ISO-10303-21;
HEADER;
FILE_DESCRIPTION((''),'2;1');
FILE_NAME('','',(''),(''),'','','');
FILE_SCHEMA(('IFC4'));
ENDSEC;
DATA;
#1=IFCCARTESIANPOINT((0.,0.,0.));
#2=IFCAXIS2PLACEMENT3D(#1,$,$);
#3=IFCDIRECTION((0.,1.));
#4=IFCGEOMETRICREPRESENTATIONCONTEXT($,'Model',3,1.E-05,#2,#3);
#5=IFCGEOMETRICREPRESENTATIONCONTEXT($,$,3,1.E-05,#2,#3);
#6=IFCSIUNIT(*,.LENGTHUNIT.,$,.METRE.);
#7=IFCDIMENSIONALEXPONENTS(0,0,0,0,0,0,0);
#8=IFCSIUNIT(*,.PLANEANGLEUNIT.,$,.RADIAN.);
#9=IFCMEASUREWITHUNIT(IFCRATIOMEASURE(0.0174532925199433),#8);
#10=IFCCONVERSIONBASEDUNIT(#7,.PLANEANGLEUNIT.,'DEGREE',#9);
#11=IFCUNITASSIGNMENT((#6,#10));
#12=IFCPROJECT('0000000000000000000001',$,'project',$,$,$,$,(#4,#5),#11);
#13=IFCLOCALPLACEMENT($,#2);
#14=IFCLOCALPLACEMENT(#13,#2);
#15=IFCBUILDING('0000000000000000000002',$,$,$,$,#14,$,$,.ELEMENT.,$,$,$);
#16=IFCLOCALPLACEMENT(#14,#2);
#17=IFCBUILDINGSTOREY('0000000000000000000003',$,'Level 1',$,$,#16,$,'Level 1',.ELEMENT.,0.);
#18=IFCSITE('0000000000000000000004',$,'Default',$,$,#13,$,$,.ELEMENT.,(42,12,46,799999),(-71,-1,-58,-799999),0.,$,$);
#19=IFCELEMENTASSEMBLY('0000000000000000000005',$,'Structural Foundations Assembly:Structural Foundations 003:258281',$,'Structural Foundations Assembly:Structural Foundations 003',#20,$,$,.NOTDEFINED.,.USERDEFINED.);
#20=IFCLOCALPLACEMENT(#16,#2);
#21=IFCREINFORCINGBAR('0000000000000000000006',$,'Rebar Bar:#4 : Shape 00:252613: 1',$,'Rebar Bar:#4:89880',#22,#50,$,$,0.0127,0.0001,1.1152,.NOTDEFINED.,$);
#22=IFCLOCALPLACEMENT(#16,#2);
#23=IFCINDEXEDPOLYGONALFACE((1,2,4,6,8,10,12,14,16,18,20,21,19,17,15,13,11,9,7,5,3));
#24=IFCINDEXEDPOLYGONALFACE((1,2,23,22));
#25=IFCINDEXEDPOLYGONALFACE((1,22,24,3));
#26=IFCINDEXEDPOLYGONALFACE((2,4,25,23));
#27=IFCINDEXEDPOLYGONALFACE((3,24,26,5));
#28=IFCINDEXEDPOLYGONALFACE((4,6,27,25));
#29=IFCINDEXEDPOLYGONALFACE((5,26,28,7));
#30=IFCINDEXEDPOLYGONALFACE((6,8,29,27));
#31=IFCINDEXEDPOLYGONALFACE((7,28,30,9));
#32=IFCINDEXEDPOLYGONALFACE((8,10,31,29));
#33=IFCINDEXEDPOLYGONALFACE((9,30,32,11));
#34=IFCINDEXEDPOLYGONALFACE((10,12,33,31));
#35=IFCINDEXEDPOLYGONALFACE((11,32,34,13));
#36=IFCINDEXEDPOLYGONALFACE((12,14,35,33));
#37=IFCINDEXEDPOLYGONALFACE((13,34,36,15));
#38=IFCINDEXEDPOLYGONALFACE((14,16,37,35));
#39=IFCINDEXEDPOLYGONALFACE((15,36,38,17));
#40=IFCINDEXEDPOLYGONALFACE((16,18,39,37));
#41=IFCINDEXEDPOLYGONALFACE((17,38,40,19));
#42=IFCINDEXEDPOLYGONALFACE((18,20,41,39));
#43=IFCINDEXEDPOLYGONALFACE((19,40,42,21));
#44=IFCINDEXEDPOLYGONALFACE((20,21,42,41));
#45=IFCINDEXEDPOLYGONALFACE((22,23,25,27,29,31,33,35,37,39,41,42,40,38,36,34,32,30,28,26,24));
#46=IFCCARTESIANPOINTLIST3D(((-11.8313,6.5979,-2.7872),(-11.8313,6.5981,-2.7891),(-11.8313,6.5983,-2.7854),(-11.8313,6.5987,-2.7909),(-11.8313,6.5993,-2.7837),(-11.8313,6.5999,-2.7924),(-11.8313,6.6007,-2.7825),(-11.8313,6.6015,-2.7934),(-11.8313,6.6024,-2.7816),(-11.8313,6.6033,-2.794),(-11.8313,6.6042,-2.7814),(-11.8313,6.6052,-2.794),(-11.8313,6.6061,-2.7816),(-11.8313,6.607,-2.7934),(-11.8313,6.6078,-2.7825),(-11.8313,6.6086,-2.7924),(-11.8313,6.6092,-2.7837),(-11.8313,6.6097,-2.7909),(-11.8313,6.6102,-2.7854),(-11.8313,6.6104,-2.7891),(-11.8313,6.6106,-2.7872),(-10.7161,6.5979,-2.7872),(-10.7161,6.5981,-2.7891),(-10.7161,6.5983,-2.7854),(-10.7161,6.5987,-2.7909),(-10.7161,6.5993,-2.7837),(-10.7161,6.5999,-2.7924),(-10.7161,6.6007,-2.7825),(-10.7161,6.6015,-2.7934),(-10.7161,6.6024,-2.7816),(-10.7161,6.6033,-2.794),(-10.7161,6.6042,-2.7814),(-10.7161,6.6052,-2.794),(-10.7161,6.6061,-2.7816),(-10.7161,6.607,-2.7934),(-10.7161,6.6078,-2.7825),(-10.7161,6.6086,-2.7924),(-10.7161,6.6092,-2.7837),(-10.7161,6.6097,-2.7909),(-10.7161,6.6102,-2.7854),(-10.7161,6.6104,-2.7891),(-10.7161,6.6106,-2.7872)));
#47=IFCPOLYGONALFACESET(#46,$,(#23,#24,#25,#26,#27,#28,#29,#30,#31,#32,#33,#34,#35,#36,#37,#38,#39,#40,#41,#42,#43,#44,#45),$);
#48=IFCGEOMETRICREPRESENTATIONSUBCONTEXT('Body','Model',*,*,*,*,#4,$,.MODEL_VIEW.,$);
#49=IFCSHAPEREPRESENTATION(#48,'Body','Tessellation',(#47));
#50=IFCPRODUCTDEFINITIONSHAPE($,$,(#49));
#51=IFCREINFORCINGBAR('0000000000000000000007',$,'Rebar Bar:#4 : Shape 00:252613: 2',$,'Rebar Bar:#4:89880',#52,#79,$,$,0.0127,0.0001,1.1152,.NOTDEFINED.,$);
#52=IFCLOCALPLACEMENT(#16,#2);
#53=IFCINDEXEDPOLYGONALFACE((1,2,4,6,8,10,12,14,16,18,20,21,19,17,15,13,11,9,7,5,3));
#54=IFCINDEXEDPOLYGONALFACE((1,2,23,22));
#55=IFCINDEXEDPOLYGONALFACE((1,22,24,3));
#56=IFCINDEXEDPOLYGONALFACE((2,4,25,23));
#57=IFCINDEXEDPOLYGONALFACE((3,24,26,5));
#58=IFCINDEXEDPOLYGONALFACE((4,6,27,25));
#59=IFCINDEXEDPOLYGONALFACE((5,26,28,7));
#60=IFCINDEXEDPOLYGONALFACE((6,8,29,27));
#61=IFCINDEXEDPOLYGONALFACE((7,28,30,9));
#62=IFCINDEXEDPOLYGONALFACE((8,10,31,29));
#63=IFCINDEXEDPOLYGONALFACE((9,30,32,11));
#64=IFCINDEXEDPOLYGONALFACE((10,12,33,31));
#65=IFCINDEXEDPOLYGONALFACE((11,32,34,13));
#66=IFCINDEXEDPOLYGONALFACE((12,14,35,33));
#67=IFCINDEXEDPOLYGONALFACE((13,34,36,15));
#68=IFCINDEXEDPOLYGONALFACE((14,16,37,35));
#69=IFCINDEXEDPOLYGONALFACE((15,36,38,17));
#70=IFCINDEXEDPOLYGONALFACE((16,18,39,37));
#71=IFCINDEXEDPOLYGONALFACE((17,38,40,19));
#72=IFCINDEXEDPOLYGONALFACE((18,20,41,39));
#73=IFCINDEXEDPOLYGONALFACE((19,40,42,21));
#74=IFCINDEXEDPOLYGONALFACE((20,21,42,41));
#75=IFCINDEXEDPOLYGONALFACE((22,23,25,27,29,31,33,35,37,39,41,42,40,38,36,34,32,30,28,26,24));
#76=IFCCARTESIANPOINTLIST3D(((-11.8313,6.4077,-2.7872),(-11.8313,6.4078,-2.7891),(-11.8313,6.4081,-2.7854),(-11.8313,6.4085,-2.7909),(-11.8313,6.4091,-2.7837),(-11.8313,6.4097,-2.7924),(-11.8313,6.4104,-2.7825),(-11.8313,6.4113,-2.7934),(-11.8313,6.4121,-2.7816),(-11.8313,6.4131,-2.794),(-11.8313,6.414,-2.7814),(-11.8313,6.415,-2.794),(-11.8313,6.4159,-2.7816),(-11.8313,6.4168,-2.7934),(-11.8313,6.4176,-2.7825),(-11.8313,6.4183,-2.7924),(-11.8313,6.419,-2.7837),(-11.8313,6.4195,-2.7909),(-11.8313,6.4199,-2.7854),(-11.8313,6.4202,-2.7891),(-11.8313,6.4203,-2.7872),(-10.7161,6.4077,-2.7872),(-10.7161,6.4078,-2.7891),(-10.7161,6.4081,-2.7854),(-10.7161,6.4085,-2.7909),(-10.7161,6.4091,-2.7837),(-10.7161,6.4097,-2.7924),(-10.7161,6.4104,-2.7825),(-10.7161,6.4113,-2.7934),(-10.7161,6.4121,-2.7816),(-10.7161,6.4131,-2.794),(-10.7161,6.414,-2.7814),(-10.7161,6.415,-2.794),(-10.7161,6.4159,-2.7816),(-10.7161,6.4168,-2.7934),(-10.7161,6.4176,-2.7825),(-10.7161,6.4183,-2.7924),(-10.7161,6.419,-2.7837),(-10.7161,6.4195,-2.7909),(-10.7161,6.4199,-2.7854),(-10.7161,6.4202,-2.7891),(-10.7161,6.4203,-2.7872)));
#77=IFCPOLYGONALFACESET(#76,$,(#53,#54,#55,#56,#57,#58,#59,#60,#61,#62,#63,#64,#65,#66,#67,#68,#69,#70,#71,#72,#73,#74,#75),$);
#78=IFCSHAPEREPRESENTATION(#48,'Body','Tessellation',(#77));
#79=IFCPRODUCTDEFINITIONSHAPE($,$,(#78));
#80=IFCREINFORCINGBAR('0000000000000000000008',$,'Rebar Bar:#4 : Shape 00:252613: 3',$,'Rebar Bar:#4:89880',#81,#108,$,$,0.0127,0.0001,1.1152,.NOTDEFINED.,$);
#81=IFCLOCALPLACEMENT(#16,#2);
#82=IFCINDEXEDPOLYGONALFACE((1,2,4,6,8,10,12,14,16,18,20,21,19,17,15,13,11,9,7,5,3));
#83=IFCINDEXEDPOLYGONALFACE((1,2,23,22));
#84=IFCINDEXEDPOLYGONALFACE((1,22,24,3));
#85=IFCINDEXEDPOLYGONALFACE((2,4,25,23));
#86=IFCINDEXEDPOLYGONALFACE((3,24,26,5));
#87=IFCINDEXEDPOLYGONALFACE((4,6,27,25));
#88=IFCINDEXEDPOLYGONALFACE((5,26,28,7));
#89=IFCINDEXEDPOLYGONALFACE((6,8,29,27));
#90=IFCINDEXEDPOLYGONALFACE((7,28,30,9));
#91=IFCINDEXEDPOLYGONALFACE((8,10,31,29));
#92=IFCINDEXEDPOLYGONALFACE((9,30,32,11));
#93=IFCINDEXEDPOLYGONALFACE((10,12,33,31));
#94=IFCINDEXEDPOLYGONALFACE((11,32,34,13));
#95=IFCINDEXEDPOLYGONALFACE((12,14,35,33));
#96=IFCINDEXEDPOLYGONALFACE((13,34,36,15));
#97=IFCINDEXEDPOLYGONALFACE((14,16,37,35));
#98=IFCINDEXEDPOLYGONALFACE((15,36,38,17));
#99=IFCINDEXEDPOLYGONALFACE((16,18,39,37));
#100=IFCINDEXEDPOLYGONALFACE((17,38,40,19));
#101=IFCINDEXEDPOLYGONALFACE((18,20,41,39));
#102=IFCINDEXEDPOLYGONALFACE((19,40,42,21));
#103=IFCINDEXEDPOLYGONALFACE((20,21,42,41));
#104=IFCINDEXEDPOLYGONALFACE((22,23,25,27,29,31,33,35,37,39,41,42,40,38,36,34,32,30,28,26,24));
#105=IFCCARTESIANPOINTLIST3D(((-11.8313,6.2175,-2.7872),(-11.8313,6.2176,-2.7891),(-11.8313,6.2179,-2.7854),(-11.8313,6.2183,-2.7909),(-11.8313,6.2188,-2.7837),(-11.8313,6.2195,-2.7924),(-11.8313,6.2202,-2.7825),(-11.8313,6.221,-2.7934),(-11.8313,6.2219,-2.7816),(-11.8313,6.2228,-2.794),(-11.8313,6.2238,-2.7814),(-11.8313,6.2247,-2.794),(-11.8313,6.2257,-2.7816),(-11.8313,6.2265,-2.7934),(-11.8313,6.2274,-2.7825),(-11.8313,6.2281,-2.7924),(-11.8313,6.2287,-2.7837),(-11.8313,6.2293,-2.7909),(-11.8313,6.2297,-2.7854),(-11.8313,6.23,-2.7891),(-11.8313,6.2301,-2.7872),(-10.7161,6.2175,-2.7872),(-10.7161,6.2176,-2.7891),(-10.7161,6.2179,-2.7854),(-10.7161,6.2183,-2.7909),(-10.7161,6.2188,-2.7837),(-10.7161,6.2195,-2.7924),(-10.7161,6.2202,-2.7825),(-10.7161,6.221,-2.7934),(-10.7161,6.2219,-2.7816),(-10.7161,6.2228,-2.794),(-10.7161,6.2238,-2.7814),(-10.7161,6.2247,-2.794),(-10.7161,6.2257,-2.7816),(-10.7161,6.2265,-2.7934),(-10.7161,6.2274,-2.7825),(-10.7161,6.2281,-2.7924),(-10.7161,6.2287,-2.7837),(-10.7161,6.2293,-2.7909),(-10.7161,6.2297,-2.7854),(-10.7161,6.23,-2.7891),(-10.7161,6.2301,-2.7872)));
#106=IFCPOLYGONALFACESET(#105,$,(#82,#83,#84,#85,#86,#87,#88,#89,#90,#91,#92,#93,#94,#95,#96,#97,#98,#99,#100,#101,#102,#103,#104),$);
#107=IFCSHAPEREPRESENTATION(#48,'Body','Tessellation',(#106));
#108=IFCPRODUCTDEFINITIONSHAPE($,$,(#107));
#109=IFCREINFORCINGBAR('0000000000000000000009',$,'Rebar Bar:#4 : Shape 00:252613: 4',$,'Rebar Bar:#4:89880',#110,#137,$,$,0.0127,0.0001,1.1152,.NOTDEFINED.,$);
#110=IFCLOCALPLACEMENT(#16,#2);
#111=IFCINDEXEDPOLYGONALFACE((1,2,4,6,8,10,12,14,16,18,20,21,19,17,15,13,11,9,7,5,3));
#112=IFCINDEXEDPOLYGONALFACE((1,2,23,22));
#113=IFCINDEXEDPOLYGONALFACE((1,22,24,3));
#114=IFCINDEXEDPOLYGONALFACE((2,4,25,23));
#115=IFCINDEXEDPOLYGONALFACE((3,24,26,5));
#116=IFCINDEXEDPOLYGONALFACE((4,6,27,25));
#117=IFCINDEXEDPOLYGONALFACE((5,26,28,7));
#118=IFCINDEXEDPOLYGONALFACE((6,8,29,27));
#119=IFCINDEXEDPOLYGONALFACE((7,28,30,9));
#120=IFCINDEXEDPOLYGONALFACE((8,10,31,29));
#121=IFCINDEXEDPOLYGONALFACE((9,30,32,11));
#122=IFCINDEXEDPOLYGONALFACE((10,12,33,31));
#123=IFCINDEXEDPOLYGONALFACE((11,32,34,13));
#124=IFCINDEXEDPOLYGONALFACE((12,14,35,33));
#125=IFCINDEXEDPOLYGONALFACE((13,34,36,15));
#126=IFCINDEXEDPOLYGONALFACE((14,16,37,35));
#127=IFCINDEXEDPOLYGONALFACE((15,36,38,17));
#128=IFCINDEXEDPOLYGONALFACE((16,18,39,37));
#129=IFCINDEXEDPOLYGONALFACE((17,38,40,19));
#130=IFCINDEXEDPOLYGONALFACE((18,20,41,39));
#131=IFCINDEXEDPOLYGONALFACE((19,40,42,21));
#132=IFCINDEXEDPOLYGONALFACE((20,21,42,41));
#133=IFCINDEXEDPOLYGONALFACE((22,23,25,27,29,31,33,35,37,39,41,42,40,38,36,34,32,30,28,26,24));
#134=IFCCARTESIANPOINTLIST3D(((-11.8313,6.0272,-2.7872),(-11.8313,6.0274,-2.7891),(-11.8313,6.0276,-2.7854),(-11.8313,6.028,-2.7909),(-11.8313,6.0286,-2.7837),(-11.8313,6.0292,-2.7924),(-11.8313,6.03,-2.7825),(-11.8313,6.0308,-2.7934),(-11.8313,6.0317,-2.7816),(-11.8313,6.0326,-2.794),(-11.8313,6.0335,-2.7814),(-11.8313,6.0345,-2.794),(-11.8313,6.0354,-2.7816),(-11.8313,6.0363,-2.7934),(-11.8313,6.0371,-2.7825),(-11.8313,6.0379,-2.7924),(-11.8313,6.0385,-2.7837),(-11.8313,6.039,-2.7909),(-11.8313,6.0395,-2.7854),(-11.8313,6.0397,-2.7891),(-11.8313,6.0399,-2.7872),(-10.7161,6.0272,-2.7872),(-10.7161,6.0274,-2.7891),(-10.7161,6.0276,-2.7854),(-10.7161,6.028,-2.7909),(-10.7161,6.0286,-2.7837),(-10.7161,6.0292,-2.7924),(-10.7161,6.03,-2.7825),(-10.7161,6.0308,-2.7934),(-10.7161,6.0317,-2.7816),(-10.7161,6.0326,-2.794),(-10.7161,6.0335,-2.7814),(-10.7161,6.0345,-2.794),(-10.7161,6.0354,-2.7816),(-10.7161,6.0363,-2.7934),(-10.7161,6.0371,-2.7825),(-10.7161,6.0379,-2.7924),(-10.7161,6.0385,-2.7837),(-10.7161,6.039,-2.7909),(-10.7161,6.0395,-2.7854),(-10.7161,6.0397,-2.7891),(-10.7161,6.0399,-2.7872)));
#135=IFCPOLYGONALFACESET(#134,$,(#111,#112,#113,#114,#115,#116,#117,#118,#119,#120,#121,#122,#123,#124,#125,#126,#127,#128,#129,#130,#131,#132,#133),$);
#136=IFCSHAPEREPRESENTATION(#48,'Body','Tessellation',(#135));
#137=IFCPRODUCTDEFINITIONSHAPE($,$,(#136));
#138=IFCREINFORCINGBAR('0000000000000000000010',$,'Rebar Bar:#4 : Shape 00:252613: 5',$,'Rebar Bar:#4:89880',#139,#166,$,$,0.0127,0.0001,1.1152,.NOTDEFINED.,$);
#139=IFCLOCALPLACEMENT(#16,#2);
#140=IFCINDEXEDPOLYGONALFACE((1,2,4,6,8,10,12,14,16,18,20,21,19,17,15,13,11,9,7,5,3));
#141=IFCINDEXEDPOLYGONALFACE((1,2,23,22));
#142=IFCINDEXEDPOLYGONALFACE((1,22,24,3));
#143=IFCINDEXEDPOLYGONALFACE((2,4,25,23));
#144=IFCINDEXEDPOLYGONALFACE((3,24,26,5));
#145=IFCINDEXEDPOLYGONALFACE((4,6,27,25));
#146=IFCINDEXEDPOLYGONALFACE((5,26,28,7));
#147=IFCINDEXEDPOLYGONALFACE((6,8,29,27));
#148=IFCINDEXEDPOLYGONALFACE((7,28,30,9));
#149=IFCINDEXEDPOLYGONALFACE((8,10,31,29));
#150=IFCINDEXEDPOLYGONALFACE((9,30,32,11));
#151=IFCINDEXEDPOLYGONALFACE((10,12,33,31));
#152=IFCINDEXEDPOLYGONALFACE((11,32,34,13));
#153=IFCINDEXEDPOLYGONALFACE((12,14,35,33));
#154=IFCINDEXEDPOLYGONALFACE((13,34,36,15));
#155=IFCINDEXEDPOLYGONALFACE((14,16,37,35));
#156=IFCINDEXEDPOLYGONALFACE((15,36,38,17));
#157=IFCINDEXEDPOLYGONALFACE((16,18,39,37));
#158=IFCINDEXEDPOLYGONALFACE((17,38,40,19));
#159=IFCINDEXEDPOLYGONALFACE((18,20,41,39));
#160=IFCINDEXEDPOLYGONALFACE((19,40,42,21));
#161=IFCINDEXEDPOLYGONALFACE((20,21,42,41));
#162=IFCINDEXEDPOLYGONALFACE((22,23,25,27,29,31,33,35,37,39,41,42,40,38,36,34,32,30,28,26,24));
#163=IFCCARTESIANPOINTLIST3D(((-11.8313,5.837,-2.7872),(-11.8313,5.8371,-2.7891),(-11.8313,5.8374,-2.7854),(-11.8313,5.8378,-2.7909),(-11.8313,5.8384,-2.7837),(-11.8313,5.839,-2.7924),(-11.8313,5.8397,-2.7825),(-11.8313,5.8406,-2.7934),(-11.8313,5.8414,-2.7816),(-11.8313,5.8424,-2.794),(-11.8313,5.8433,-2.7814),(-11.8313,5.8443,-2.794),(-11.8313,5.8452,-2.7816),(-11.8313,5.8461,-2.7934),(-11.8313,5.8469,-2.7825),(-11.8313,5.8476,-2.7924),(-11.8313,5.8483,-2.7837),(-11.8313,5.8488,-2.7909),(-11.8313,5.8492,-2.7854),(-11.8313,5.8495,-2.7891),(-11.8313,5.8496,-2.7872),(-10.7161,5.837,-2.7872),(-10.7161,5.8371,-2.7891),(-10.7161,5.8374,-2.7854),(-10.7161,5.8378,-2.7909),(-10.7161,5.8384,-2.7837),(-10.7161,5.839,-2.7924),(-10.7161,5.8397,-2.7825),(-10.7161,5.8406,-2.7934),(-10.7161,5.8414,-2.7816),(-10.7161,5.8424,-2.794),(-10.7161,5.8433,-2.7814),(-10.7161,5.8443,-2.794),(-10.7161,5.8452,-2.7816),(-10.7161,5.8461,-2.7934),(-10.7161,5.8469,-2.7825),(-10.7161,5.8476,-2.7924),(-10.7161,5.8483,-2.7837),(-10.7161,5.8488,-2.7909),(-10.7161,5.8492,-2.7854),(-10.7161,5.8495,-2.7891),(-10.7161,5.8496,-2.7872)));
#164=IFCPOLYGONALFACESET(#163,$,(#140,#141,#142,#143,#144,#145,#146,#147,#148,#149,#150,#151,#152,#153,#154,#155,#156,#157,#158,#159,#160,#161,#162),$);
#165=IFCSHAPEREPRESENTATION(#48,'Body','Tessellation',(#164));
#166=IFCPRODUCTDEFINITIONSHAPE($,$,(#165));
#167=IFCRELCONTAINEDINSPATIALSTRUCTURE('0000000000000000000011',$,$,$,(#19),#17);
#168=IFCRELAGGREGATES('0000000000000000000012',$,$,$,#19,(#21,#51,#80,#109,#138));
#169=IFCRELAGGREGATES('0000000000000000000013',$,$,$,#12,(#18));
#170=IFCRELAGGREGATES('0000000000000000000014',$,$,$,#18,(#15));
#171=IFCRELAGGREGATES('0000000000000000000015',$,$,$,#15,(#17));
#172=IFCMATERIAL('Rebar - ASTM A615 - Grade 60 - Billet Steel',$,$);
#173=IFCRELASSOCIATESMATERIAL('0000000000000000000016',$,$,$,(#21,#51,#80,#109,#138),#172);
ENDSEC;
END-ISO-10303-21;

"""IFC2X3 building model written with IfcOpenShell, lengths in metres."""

from ifc_helpers import new_model, entity, si_unit, converted_unit, direction, origin, place, context, subcontext, project, spatial, material, element, aggregate, save


model = new_model("IFC2X3")

# Units and contexts
model_context = context("Model", 3, precision=1e-05, world=origin(), true_north=direction((0.0, 1.0)))
context_of_model = context(None, 3, precision=1e-05, world=origin(), true_north=direction((0.0, 1.0)))
body_context = subcontext(model_context, "Body", "Model", "MODEL_VIEW")
ifc_project = project(units=[si_unit("LENGTHUNIT", "METRE"), converted_unit("PLANEANGLEUNIT", "DEGREE", entity("IfcRatioMeasure", 0.0174532925199433), si_unit("PLANEANGLEUNIT", "RADIAN"), dimensions=[0, 0, 0, 0, 0, 0, 0])], contexts=[model_context, context_of_model])

# Site, building, storey
site_placement = place(None, origin())
site = spatial("IfcSite", under=ifc_project, at=site_placement, Name="Default", CompositionType="ELEMENT", RefLatitude=(42, 12, 46, 799999), RefLongitude=(-71, -1, -58, -799999), RefElevation=0.0)
building_placement = place(site_placement, origin())
building = spatial("IfcBuilding", under=site, at=building_placement, CompositionType="ELEMENT")
storey_placement = place(building_placement, origin())
storey = spatial("IfcBuildingStorey", under=building, at=storey_placement, Name="Level 1", LongName="Level 1", CompositionType="ELEMENT", Elevation=0.0)

# Element assembly
assembly_1_placement = place(storey_placement, origin())
assembly_1 = element("IfcElementAssembly", 1, at=assembly_1_placement, inside=storey, Name="Structural Foundations Assembly:Structural Foundations 003:258281", ObjectType="Structural Foundations Assembly:Structural Foundations 003", AssemblyPlace="NOTDEFINED", PredefinedType="USERDEFINED")

# Shared definitions
ifc_material_1 = material(Name="Rebar - ASTM A615 - Grade 60 - Billet Steel")

# Reinforcing bars
reinforcing_bar_1_placement = place(assembly_1_placement, origin())
reinforcing_bar_1 = element("IfcReinforcingBar", 2, at=reinforcing_bar_1_placement, material=ifc_material_1, Name="Rebar Bar:#4 : Shape 00:252613: 1", ObjectType="Rebar Bar:#4:89880", BarLength=1.1152, BarRole="NOTDEFINED", CrossSectionArea=0.0001, NominalDiameter=0.0127, context=body_context, shape_type="AdvancedSweptSolid", body=[
    entity("IfcSweptDiskSolid", entity("IfcCompositeCurve", [entity("IfcCompositeCurveSegment", "CONTINUOUS", True, entity("IfcPolyline", [entity("IfcCartesianPoint", [-11.8313, 6.6042, -2.7877]), entity("IfcCartesianPoint", [-10.7161, 6.6042, -2.7877])]))], False), 0.0063, None, 0.0, 1.0),
])
reinforcing_bar_2_placement = place(assembly_1_placement, origin())
reinforcing_bar_2 = element("IfcReinforcingBar", 3, at=reinforcing_bar_2_placement, material=ifc_material_1, Name="Rebar Bar:#4 : Shape 00:252613: 2", ObjectType="Rebar Bar:#4:89880", BarLength=1.1152, BarRole="NOTDEFINED", CrossSectionArea=0.0001, NominalDiameter=0.0127, context=body_context, shape_type="AdvancedSweptSolid", body=[
    entity("IfcSweptDiskSolid", entity("IfcCompositeCurve", [entity("IfcCompositeCurveSegment", "CONTINUOUS", True, entity("IfcPolyline", [entity("IfcCartesianPoint", [-11.8313, 6.414, -2.7877]), entity("IfcCartesianPoint", [-10.7161, 6.414, -2.7877])]))], False), 0.0063, None, 0.0, 1.0),
])
reinforcing_bar_3_placement = place(assembly_1_placement, origin())
reinforcing_bar_3 = element("IfcReinforcingBar", 4, at=reinforcing_bar_3_placement, material=ifc_material_1, Name="Rebar Bar:#4 : Shape 00:252613: 3", ObjectType="Rebar Bar:#4:89880", BarLength=1.1152, BarRole="NOTDEFINED", CrossSectionArea=0.0001, NominalDiameter=0.0127, context=body_context, shape_type="AdvancedSweptSolid", body=[
    entity("IfcSweptDiskSolid", entity("IfcCompositeCurve", [entity("IfcCompositeCurveSegment", "CONTINUOUS", True, entity("IfcPolyline", [entity("IfcCartesianPoint", [-11.8313, 6.2238, -2.7877]), entity("IfcCartesianPoint", [-10.7161, 6.2238, -2.7877])]))], False), 0.0063, None, 0.0, 1.0),
])
reinforcing_bar_4_placement = place(assembly_1_placement, origin())
reinforcing_bar_4 = element("IfcReinforcingBar", 5, at=reinforcing_bar_4_placement, material=ifc_material_1, Name="Rebar Bar:#4 : Shape 00:252613: 4", ObjectType="Rebar Bar:#4:89880", BarLength=1.1152, BarRole="NOTDEFINED", CrossSectionArea=0.0001, NominalDiameter=0.0127, context=body_context, shape_type="AdvancedSweptSolid", body=[
    entity("IfcSweptDiskSolid", entity("IfcCompositeCurve", [entity("IfcCompositeCurveSegment", "CONTINUOUS", True, entity("IfcPolyline", [entity("IfcCartesianPoint", [-11.8313, 6.0335, -2.7877]), entity("IfcCartesianPoint", [-10.7161, 6.0335, -2.7877])]))], False), 0.0063, None, 0.0, 1.0),
])
reinforcing_bar_5_placement = place(assembly_1_placement, origin())
reinforcing_bar_5 = element("IfcReinforcingBar", 6, at=reinforcing_bar_5_placement, material=ifc_material_1, Name="Rebar Bar:#4 : Shape 00:252613: 5", ObjectType="Rebar Bar:#4:89880", BarLength=1.1152, BarRole="NOTDEFINED", CrossSectionArea=0.0001, NominalDiameter=0.0127, context=body_context, shape_type="AdvancedSweptSolid", body=[
    entity("IfcSweptDiskSolid", entity("IfcCompositeCurve", [entity("IfcCompositeCurveSegment", "CONTINUOUS", True, entity("IfcPolyline", [entity("IfcCartesianPoint", [-11.8313, 5.8433, -2.7877]), entity("IfcCartesianPoint", [-10.7161, 5.8433, -2.7877])]))], False), 0.0063, None, 0.0, 1.0),
])
aggregate(assembly_1, [reinforcing_bar_1, reinforcing_bar_2, reinforcing_bar_3, reinforcing_bar_4, reinforcing_bar_5])

save(model, "model.ifc")
